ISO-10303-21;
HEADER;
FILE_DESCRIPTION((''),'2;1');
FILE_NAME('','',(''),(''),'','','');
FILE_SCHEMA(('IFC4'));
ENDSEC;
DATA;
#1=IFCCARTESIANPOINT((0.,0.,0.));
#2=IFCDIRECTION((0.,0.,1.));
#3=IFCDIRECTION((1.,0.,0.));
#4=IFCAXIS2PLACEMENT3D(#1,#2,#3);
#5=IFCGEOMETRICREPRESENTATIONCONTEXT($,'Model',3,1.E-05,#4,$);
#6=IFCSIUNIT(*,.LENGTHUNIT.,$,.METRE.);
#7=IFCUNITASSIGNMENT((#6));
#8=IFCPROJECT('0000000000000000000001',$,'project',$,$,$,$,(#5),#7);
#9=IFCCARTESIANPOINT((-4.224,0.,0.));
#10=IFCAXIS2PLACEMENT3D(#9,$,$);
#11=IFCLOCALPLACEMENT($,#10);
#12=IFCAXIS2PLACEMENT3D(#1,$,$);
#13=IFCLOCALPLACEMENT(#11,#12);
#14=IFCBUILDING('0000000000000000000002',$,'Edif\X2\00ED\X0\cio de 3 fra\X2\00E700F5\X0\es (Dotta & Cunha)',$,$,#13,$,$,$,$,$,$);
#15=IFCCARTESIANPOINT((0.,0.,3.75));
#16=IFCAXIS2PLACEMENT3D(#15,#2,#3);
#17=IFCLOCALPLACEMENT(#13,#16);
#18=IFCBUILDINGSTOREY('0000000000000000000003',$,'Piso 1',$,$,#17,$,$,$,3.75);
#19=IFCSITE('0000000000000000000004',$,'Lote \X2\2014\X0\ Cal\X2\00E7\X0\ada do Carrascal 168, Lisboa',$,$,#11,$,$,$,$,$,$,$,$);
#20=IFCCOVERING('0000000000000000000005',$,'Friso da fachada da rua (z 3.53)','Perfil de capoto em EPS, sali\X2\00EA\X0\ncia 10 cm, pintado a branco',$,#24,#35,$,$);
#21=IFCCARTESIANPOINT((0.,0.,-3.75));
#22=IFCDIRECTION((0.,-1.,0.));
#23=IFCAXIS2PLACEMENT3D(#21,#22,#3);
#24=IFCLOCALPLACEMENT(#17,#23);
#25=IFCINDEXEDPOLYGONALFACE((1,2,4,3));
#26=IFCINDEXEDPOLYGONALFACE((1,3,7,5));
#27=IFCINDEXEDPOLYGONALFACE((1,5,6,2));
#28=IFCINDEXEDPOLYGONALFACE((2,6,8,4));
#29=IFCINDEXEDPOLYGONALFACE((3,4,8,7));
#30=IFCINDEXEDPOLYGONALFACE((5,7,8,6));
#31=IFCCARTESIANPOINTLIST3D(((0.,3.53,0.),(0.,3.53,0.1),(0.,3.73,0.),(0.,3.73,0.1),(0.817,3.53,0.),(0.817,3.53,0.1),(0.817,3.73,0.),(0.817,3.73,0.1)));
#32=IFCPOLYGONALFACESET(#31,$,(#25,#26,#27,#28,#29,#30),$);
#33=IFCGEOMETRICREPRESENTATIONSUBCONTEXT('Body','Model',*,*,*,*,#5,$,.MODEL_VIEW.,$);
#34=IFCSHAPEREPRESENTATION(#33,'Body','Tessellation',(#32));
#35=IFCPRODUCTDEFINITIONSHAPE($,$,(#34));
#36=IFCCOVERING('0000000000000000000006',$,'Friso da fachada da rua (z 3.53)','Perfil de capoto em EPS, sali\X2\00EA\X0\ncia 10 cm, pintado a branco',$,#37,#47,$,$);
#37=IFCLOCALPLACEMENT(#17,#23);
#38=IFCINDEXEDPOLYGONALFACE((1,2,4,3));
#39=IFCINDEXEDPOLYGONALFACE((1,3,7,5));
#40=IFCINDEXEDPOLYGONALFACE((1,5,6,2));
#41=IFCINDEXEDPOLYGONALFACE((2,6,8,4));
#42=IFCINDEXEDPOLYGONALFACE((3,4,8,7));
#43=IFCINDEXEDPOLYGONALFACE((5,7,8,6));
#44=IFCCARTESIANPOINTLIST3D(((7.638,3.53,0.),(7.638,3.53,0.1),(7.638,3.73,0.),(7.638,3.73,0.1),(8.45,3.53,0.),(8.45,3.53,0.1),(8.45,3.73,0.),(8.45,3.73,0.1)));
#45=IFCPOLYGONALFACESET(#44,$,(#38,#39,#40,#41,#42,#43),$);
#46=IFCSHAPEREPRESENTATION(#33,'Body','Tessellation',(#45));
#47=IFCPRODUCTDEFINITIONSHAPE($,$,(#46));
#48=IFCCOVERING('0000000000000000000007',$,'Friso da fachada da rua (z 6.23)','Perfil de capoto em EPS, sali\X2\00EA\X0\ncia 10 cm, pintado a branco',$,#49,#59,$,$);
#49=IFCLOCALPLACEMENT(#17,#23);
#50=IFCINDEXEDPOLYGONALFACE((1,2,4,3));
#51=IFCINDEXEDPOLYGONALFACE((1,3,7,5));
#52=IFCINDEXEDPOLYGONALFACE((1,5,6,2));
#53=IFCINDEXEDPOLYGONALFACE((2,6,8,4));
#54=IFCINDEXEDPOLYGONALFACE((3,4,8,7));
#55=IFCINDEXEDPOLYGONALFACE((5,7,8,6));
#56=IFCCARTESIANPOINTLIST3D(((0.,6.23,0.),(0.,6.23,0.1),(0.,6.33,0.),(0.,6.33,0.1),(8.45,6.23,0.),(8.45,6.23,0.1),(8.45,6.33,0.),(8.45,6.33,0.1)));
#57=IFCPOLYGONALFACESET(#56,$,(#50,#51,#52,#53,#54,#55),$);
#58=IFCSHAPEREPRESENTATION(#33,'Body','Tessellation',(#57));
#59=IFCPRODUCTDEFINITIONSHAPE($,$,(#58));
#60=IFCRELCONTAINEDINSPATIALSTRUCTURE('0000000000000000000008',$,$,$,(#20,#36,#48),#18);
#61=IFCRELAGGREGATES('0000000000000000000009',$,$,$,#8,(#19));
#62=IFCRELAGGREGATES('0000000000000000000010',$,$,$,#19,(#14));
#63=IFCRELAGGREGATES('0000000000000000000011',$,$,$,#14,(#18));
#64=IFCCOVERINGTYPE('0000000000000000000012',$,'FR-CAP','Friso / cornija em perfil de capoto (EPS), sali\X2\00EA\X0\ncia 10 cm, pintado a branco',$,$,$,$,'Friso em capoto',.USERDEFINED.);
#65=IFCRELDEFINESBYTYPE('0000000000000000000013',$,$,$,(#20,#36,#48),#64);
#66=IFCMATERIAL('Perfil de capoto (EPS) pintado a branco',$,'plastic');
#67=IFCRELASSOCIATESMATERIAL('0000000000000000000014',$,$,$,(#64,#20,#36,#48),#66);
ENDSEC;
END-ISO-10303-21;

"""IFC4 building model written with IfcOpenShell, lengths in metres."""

from ifc_helpers import new_model, si_unit, frame, origin, origin_with_axes, place, context, subcontext, project, spatial, line, indexed_curve, outline, extrude, material, type_object, element, save


model = new_model("IFC4")

# Units and contexts
model_context = context("Model", 3, precision=1e-05, world=origin_with_axes())
body_context = subcontext(model_context, "Body", "Model", "MODEL_VIEW")
ifc_project = project(units=[si_unit("LENGTHUNIT", "METRE")], contexts=[model_context])

# Site, building, storey
site_placement = place(None, frame((-4.224, 0.0, 0.0)))
site = spatial("IfcSite", under=ifc_project, at=site_placement, Name="Lote — Calçada do Carrascal 168, Lisboa")
building_placement = place(site_placement, origin())
building = spatial("IfcBuilding", under=site, at=building_placement, Name="Edifício de 3 frações (Dotta & Cunha)")
storey_placement = place(building_placement, frame((0.0, 0.0, 3.75), z_axis=(0.0, 0.0, 1.0), x_axis=(1.0, 0.0, 0.0)))
storey = spatial("IfcBuildingStorey", under=building, at=storey_placement, Name="Piso 1", Elevation=3.75)

# Coverings
ifc_material_1 = material(Name="Perfil de capoto (EPS) pintado a branco", Category="plastic")
covering_type_1 = type_object("IfcCoveringType", Name="FR-CAP", Description="Friso / cornija em perfil de capoto (EPS), saliência 10 cm, pintado a branco", ElementType="Friso em capoto", PredefinedType="USERDEFINED", material=ifc_material_1)
covering_1_placement = place(storey_placement, frame((0.0, 0.0, -3.75), z_axis=(0.0, -1.0, 0.0), x_axis=(1.0, 0.0, 0.0)))
element("IfcCovering", 1, at=covering_1_placement, inside=storey, type_object=covering_type_1, material=ifc_material_1, Name="Friso da fachada da rua (z 3.53)", Description="Perfil de capoto em EPS, saliência 10 cm, pintado a branco", context=body_context, shape_type="SweptSolid", body=[
    extrude(outline(indexed_curve([(0.817, 3.53), (0.817, 3.73), (0.0, 3.73), (0.0, 3.53)], segments=[line(1, 2, 3, 4, 1)])), origin_with_axes(), (0.0, 0.0, 1.0), 0.1),
])
covering_2_placement = place(storey_placement, frame((0.0, 0.0, -3.75), z_axis=(0.0, -1.0, 0.0), x_axis=(1.0, 0.0, 0.0)))
element("IfcCovering", 2, at=covering_2_placement, inside=storey, type_object=covering_type_1, material=ifc_material_1, Name="Friso da fachada da rua (z 3.53)", Description="Perfil de capoto em EPS, saliência 10 cm, pintado a branco", context=body_context, shape_type="SweptSolid", body=[
    extrude(outline(indexed_curve([(8.45, 3.53), (8.45, 3.73), (7.638, 3.73), (7.638, 3.53)], segments=[line(1, 2, 3, 4, 1)])), origin_with_axes(), (0.0, 0.0, 1.0), 0.1),
])
covering_3_placement = place(storey_placement, frame((0.0, 0.0, -3.75), z_axis=(0.0, -1.0, 0.0), x_axis=(1.0, 0.0, 0.0)))
element("IfcCovering", 3, at=covering_3_placement, inside=storey, type_object=covering_type_1, material=ifc_material_1, Name="Friso da fachada da rua (z 6.23)", Description="Perfil de capoto em EPS, saliência 10 cm, pintado a branco", context=body_context, shape_type="SweptSolid", body=[
    extrude(outline(indexed_curve([(8.45, 6.23), (8.45, 6.33), (0.0, 6.33), (0.0, 6.23)], segments=[line(1, 2, 3, 4, 1)])), origin_with_axes(), (0.0, 0.0, 1.0), 0.1),
])

save(model, "model.ifc")
